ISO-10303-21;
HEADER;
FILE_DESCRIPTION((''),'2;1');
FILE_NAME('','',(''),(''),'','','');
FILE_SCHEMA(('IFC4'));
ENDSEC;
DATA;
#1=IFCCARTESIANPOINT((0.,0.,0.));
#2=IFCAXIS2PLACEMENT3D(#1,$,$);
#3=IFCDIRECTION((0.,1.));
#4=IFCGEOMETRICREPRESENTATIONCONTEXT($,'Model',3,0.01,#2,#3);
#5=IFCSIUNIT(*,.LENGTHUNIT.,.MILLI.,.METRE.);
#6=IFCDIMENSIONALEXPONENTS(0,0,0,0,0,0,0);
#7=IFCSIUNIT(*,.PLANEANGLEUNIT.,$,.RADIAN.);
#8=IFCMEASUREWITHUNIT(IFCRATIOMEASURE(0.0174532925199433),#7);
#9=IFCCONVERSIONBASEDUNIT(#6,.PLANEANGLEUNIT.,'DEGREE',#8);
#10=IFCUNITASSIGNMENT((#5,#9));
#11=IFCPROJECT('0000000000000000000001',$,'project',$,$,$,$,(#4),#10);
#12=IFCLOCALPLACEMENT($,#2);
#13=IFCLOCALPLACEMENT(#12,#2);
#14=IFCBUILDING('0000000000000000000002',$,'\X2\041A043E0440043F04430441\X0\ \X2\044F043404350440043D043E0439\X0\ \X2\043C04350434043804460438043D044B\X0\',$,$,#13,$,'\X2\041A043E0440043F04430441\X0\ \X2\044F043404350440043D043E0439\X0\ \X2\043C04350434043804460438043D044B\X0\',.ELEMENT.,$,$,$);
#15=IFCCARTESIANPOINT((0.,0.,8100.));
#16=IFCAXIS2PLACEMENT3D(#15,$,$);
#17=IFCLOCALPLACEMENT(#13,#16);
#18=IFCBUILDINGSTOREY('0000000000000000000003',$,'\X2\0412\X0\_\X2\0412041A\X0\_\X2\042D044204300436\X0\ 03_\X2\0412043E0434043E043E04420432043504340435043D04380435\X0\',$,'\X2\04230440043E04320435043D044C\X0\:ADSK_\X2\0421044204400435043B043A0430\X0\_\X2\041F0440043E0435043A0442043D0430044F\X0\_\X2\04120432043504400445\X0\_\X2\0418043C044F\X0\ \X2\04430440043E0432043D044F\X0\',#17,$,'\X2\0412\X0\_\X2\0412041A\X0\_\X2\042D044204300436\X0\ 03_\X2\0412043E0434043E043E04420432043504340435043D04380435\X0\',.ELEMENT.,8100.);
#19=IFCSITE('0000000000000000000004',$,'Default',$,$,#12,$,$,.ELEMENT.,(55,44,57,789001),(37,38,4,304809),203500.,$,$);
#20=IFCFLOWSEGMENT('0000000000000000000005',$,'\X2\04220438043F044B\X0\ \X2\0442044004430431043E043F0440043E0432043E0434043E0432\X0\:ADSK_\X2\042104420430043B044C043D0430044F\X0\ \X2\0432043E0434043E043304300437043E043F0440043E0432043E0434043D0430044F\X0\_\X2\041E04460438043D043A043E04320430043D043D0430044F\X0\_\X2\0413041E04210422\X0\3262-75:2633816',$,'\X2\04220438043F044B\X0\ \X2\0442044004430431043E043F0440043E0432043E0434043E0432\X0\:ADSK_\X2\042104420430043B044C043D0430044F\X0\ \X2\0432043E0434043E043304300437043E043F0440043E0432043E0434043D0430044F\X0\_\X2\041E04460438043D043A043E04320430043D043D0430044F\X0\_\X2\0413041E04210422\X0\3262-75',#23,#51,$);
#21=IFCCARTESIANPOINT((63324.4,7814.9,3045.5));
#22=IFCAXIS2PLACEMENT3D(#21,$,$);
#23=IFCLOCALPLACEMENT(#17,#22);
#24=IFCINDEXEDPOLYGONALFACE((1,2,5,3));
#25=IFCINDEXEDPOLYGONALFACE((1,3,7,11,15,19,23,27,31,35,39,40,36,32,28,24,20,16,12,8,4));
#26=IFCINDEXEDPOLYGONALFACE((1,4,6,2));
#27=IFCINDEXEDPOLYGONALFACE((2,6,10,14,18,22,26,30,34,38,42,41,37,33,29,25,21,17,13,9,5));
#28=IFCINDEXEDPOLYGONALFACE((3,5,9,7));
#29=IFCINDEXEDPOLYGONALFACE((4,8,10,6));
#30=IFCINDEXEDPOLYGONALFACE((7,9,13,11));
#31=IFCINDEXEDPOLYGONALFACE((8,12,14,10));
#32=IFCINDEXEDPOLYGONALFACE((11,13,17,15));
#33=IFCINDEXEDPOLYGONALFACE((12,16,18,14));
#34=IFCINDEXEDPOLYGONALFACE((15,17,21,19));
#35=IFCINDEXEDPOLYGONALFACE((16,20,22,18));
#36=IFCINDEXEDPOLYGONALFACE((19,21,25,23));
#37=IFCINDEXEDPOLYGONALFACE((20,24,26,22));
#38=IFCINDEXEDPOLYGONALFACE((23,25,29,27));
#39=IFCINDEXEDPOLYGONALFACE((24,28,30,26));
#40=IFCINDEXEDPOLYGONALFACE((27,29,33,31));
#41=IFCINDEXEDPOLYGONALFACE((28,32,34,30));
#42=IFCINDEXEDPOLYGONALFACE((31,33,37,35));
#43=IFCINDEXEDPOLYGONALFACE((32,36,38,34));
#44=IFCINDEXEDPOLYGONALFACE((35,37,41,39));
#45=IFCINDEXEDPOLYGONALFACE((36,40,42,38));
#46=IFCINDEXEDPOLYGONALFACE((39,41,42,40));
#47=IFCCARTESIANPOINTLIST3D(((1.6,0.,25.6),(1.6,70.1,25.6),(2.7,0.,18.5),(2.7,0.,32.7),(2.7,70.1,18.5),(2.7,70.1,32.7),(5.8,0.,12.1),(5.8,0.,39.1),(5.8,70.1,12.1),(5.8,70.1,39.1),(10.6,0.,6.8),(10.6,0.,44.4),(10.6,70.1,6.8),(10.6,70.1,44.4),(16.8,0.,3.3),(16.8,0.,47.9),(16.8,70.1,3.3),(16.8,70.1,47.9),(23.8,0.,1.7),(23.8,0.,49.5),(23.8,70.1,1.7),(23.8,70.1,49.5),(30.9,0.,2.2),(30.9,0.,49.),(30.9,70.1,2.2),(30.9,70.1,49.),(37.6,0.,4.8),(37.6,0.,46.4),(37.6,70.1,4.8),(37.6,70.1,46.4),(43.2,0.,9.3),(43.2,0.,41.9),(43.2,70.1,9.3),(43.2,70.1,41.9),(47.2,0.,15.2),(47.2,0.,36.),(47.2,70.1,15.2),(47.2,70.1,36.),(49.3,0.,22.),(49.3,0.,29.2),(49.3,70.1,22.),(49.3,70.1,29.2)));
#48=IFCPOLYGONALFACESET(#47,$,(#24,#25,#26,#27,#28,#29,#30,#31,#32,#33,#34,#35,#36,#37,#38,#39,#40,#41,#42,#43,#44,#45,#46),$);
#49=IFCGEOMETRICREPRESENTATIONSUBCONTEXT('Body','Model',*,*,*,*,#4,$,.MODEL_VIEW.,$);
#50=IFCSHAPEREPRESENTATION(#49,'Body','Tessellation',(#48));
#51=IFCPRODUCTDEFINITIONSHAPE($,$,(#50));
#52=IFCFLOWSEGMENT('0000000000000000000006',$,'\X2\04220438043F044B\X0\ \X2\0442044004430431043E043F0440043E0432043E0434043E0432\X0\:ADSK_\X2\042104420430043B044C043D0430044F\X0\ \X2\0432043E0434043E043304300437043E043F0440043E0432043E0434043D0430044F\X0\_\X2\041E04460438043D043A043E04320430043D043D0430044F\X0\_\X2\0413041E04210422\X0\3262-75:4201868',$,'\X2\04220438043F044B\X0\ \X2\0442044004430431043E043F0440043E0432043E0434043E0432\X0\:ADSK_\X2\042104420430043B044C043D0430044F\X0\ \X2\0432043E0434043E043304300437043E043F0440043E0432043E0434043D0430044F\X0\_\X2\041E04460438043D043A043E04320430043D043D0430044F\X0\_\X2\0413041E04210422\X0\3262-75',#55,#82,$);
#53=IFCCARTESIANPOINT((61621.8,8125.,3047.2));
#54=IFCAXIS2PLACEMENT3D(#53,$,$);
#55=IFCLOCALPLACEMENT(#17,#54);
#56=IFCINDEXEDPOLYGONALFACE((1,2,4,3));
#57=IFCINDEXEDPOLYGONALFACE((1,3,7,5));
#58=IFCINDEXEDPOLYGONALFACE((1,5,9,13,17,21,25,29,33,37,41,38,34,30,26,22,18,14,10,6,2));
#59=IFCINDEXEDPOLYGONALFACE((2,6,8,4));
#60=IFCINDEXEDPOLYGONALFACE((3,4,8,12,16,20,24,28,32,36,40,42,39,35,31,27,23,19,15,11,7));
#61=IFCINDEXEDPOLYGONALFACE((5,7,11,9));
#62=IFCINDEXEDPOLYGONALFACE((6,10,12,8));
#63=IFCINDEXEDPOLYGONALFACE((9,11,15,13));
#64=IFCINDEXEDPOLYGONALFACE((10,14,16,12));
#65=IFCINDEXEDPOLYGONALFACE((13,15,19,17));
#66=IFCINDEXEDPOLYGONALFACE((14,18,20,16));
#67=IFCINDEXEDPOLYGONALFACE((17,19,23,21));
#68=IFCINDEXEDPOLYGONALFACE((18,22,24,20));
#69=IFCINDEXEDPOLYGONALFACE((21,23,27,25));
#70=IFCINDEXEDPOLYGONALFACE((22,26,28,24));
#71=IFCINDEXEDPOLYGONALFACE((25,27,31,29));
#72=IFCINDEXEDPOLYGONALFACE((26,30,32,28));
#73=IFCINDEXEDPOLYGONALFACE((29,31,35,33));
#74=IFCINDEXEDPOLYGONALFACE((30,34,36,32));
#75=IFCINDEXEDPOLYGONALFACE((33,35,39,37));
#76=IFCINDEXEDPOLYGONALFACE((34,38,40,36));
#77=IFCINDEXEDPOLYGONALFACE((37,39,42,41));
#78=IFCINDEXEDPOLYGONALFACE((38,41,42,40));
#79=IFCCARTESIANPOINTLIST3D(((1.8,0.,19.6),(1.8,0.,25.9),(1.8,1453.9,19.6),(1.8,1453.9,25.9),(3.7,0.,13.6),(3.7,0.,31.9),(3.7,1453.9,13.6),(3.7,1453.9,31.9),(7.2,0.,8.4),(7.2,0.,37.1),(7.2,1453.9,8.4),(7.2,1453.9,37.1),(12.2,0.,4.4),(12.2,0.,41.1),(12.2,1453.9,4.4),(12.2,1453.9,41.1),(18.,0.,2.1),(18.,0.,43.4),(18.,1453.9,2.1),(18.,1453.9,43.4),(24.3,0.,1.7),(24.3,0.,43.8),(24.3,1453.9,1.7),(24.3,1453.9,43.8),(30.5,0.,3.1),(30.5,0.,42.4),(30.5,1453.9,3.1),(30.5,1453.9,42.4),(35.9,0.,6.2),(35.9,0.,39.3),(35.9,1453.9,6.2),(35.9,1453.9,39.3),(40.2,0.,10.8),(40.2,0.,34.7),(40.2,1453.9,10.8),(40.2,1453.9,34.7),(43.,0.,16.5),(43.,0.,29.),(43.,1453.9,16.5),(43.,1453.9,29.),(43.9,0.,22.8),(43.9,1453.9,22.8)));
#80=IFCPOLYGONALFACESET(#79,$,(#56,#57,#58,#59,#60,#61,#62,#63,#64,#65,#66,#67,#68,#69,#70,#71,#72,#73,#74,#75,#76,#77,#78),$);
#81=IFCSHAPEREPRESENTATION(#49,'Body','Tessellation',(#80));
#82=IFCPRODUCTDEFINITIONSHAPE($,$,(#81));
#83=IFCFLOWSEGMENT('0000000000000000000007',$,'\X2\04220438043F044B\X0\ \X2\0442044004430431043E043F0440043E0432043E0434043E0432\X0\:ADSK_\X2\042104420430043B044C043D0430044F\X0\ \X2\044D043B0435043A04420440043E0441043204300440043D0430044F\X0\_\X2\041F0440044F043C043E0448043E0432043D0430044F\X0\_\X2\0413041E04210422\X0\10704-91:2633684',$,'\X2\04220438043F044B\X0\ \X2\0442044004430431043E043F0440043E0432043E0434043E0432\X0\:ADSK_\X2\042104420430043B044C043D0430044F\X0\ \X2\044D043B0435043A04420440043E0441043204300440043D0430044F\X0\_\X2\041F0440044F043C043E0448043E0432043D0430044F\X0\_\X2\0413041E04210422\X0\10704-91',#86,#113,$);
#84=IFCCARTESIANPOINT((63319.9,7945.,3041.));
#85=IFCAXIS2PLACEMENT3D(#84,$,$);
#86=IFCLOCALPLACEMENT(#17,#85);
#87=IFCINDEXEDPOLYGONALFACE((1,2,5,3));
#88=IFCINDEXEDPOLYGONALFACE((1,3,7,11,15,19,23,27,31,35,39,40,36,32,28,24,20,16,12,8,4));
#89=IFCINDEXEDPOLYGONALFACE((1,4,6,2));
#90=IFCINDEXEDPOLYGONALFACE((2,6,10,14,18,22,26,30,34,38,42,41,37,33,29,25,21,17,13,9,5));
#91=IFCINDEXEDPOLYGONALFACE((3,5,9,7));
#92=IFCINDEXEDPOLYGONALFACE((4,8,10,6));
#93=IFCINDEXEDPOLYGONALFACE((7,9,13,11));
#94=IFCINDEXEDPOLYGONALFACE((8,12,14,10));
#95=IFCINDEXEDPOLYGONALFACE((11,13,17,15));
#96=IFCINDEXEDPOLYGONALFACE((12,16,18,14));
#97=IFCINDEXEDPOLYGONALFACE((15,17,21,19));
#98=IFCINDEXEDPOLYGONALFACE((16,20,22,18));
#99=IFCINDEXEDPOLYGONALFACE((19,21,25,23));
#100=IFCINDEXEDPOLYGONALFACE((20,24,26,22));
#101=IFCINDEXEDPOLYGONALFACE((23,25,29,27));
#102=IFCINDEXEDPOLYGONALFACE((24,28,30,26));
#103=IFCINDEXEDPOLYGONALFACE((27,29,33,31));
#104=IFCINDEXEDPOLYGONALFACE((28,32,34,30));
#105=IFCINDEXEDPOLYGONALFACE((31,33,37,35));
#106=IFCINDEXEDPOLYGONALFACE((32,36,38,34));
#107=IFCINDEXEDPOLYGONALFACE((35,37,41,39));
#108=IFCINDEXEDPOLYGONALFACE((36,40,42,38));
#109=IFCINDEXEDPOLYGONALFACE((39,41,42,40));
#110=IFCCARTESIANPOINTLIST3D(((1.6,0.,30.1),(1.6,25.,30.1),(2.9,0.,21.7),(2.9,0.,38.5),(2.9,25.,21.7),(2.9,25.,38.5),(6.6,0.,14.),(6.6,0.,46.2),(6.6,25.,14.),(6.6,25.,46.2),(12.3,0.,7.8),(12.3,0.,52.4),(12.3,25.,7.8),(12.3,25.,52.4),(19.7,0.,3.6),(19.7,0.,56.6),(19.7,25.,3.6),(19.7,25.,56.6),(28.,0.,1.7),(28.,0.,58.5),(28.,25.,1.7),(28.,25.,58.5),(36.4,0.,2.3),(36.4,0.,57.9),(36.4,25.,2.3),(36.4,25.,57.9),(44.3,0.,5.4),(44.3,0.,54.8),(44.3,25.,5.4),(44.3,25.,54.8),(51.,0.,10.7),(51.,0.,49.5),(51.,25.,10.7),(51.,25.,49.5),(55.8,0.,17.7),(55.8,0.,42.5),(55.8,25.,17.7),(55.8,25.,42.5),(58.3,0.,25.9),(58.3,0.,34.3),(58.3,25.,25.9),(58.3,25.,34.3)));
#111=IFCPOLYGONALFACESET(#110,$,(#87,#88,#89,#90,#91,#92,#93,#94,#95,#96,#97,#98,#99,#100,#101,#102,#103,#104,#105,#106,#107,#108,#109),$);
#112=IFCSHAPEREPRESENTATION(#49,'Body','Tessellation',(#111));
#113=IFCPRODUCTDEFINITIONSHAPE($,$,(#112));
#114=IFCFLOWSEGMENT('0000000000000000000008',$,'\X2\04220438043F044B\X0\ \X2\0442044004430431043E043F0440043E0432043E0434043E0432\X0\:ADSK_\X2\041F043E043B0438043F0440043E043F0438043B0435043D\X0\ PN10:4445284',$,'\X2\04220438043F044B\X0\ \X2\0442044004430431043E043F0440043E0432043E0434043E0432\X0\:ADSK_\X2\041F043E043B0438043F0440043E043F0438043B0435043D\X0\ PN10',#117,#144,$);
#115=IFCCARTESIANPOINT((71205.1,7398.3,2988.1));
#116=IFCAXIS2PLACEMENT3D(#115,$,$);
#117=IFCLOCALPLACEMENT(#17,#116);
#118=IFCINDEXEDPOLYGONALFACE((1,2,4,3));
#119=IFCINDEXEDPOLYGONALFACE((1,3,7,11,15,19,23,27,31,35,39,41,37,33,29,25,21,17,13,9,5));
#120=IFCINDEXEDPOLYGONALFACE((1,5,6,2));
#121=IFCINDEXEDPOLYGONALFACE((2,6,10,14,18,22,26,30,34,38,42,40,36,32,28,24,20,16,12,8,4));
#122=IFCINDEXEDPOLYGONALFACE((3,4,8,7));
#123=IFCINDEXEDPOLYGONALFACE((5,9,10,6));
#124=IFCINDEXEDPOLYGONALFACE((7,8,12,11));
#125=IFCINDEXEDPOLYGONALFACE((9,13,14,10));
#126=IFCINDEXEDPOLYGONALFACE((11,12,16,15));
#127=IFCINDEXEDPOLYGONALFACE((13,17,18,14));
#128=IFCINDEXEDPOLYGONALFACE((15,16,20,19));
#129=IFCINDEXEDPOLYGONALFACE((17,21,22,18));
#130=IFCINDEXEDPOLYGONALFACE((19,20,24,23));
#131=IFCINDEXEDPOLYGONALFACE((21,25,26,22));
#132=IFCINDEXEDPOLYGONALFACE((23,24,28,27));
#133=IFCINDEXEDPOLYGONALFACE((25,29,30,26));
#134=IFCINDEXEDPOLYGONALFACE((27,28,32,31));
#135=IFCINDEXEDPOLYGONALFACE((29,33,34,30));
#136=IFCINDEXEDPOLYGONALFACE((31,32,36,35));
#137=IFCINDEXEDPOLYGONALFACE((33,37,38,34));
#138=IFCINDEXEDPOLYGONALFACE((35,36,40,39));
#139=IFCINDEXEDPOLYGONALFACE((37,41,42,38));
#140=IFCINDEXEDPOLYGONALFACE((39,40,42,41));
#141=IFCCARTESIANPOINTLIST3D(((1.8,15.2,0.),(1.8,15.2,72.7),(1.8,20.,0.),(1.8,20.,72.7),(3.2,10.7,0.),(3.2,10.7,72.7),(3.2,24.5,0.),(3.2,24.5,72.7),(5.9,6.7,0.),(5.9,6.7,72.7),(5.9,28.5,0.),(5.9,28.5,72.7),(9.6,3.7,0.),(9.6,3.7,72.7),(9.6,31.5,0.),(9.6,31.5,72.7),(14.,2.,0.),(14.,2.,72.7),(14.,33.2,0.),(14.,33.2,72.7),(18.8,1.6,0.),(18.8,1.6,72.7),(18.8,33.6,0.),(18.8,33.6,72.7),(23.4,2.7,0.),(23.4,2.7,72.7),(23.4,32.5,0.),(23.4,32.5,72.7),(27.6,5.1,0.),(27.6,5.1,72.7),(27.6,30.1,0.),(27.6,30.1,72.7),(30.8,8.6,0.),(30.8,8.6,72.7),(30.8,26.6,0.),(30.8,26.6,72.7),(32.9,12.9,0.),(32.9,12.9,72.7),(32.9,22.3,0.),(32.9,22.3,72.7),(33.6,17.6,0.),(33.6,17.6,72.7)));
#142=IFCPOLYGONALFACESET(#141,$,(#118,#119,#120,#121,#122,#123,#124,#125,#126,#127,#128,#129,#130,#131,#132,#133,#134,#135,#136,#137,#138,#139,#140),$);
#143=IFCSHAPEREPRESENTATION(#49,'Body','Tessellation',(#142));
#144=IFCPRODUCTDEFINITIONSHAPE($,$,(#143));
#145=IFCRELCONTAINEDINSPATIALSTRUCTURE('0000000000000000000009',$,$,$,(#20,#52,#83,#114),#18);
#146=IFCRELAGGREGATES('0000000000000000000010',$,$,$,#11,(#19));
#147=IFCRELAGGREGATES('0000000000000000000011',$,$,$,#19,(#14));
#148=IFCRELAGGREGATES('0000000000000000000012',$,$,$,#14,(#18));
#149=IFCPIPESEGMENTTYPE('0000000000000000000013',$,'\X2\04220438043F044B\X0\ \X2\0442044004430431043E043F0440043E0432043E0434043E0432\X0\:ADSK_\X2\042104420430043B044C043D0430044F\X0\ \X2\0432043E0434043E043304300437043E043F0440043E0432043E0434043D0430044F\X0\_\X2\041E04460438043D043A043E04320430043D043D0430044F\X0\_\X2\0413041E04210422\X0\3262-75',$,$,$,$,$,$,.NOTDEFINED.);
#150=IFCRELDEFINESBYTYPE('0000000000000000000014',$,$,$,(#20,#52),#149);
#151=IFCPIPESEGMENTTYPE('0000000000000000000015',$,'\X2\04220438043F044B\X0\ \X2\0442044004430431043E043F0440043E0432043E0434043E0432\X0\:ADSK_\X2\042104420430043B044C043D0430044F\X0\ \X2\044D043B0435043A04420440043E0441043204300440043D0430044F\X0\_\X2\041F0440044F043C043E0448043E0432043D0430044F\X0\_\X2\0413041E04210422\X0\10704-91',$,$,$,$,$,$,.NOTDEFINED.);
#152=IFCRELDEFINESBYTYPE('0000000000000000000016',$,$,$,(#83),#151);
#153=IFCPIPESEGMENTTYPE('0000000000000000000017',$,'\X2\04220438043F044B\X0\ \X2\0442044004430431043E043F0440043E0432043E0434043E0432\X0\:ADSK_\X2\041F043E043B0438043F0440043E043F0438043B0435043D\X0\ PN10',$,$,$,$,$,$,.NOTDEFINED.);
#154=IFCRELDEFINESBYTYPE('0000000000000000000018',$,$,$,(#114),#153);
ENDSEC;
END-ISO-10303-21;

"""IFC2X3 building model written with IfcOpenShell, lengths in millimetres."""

from ifc_helpers import new_model, entity, si_unit, converted_unit, direction, frame, origin, origin_2d_with_axis, place, context, subcontext, project, spatial, circle, extrude, type_object, element, save


model = new_model("IFC2X3")

# Units and contexts
model_context = context("Model", 3, precision=0.01, world=origin(), true_north=direction((0.0, 1.0)))
body_context = subcontext(model_context, "Body", "Model", "MODEL_VIEW")
ifc_project = project(units=[si_unit("LENGTHUNIT", "METRE", prefix="MILLI"), converted_unit("PLANEANGLEUNIT", "DEGREE", entity("IfcRatioMeasure", 0.0174532925199433), si_unit("PLANEANGLEUNIT", "RADIAN"), dimensions=[0, 0, 0, 0, 0, 0, 0])], contexts=[model_context])

# Site, building, storey
site_placement = place(None, origin())
site = spatial("IfcSite", under=ifc_project, at=site_placement, Name="Default", CompositionType="ELEMENT", RefLatitude=(55, 44, 57, 789001), RefLongitude=(37, 38, 4, 304809), RefElevation=203500.0)
building_placement = place(site_placement, origin())
building = spatial("IfcBuilding", under=site, at=building_placement, Name="Корпус ядерной медицины", LongName="Корпус ядерной медицины", CompositionType="ELEMENT")
storey_placement = place(building_placement, frame((0.0, 0.0, 8100.0)))
storey = spatial("IfcBuildingStorey", under=building, at=storey_placement, Name="В_ВК_Этаж 03_Водоотведение", ObjectType="Уровень:ADSK_Стрелка_Проектная_Вверх_Имя уровня", LongName="В_ВК_Этаж 03_Водоотведение", CompositionType="ELEMENT", Elevation=8100.0)

# Flow segments
pipe_segment_type_1 = type_object("IfcPipeSegmentType", Name="Типы трубопроводов:ADSK_Стальная водогазопроводная_Оцинкованная_ГОСТ3262-75", PredefinedType="NOTDEFINED")
flow_segment_1_placement = place(storey_placement, frame((63324.4, 7814.9, 3045.5)))
element("IfcFlowSegment", 1, at=flow_segment_1_placement, inside=storey, type_object=pipe_segment_type_1, Name="Типы трубопроводов:ADSK_Стальная водогазопроводная_Оцинкованная_ГОСТ3262-75:2633816", ObjectType="Типы трубопроводов:ADSK_Стальная водогазопроводная_Оцинкованная_ГОСТ3262-75", context=body_context, shape_type="SweptSolid", body=[
    extrude(circle(Radius=24.0, at=origin_2d_with_axis()), frame((25.6, 0.0, 25.6), z_axis=(0.0, 1.0, 0.0), x_axis=(-1.0, 0.0, 0.0)), (0.0, 0.0, 1.0), 70.1),
])
flow_segment_2_placement = place(storey_placement, frame((61621.8, 8125.0, 3047.2)))
element("IfcFlowSegment", 2, at=flow_segment_2_placement, inside=storey, type_object=pipe_segment_type_1, Name="Типы трубопроводов:ADSK_Стальная водогазопроводная_Оцинкованная_ГОСТ3262-75:4201868", ObjectType="Типы трубопроводов:ADSK_Стальная водогазопроводная_Оцинкованная_ГОСТ3262-75", context=body_context, shape_type="SweptSolid", body=[
    extrude(circle(Radius=21.1, at=origin_2d_with_axis()), frame((22.8, 0.0, 22.8), z_axis=(0.0, 1.0, 0.0), x_axis=(1.0, 0.0, 0.0)), (0.0, 0.0, 1.0), 1453.9),
])
pipe_segment_type_2 = type_object("IfcPipeSegmentType", Name="Типы трубопроводов:ADSK_Стальная электросварная_Прямошовная_ГОСТ10704-91", PredefinedType="NOTDEFINED")
flow_segment_3_placement = place(storey_placement, frame((63319.9, 7945.0, 3041.0)))
element("IfcFlowSegment", 3, at=flow_segment_3_placement, inside=storey, type_object=pipe_segment_type_2, Name="Типы трубопроводов:ADSK_Стальная электросварная_Прямошовная_ГОСТ10704-91:2633684", ObjectType="Типы трубопроводов:ADSK_Стальная электросварная_Прямошовная_ГОСТ10704-91", context=body_context, shape_type="SweptSolid", body=[
    extrude(circle(Radius=28.5, at=origin_2d_with_axis()), frame((30.1, 0.0, 30.1), z_axis=(0.0, 1.0, 0.0), x_axis=(-1.0, 0.0, 0.0)), (0.0, 0.0, 1.0), 25.0),
])
pipe_segment_type_3 = type_object("IfcPipeSegmentType", Name="Типы трубопроводов:ADSK_Полипропилен PN10", PredefinedType="NOTDEFINED")
flow_segment_4_placement = place(storey_placement, frame((71205.1, 7398.3, 2988.1)))
element("IfcFlowSegment", 4, at=flow_segment_4_placement, inside=storey, type_object=pipe_segment_type_3, Name="Типы трубопроводов:ADSK_Полипропилен PN10:4445284", ObjectType="Типы трубопроводов:ADSK_Полипропилен PN10", context=body_context, shape_type="SweptSolid", body=[
    extrude(circle(Radius=16.0, at=origin_2d_with_axis()), frame((17.6, 17.6, 0.0)), (0.0, 0.0, 1.0), 72.7),
])

save(model, "model.ifc")
